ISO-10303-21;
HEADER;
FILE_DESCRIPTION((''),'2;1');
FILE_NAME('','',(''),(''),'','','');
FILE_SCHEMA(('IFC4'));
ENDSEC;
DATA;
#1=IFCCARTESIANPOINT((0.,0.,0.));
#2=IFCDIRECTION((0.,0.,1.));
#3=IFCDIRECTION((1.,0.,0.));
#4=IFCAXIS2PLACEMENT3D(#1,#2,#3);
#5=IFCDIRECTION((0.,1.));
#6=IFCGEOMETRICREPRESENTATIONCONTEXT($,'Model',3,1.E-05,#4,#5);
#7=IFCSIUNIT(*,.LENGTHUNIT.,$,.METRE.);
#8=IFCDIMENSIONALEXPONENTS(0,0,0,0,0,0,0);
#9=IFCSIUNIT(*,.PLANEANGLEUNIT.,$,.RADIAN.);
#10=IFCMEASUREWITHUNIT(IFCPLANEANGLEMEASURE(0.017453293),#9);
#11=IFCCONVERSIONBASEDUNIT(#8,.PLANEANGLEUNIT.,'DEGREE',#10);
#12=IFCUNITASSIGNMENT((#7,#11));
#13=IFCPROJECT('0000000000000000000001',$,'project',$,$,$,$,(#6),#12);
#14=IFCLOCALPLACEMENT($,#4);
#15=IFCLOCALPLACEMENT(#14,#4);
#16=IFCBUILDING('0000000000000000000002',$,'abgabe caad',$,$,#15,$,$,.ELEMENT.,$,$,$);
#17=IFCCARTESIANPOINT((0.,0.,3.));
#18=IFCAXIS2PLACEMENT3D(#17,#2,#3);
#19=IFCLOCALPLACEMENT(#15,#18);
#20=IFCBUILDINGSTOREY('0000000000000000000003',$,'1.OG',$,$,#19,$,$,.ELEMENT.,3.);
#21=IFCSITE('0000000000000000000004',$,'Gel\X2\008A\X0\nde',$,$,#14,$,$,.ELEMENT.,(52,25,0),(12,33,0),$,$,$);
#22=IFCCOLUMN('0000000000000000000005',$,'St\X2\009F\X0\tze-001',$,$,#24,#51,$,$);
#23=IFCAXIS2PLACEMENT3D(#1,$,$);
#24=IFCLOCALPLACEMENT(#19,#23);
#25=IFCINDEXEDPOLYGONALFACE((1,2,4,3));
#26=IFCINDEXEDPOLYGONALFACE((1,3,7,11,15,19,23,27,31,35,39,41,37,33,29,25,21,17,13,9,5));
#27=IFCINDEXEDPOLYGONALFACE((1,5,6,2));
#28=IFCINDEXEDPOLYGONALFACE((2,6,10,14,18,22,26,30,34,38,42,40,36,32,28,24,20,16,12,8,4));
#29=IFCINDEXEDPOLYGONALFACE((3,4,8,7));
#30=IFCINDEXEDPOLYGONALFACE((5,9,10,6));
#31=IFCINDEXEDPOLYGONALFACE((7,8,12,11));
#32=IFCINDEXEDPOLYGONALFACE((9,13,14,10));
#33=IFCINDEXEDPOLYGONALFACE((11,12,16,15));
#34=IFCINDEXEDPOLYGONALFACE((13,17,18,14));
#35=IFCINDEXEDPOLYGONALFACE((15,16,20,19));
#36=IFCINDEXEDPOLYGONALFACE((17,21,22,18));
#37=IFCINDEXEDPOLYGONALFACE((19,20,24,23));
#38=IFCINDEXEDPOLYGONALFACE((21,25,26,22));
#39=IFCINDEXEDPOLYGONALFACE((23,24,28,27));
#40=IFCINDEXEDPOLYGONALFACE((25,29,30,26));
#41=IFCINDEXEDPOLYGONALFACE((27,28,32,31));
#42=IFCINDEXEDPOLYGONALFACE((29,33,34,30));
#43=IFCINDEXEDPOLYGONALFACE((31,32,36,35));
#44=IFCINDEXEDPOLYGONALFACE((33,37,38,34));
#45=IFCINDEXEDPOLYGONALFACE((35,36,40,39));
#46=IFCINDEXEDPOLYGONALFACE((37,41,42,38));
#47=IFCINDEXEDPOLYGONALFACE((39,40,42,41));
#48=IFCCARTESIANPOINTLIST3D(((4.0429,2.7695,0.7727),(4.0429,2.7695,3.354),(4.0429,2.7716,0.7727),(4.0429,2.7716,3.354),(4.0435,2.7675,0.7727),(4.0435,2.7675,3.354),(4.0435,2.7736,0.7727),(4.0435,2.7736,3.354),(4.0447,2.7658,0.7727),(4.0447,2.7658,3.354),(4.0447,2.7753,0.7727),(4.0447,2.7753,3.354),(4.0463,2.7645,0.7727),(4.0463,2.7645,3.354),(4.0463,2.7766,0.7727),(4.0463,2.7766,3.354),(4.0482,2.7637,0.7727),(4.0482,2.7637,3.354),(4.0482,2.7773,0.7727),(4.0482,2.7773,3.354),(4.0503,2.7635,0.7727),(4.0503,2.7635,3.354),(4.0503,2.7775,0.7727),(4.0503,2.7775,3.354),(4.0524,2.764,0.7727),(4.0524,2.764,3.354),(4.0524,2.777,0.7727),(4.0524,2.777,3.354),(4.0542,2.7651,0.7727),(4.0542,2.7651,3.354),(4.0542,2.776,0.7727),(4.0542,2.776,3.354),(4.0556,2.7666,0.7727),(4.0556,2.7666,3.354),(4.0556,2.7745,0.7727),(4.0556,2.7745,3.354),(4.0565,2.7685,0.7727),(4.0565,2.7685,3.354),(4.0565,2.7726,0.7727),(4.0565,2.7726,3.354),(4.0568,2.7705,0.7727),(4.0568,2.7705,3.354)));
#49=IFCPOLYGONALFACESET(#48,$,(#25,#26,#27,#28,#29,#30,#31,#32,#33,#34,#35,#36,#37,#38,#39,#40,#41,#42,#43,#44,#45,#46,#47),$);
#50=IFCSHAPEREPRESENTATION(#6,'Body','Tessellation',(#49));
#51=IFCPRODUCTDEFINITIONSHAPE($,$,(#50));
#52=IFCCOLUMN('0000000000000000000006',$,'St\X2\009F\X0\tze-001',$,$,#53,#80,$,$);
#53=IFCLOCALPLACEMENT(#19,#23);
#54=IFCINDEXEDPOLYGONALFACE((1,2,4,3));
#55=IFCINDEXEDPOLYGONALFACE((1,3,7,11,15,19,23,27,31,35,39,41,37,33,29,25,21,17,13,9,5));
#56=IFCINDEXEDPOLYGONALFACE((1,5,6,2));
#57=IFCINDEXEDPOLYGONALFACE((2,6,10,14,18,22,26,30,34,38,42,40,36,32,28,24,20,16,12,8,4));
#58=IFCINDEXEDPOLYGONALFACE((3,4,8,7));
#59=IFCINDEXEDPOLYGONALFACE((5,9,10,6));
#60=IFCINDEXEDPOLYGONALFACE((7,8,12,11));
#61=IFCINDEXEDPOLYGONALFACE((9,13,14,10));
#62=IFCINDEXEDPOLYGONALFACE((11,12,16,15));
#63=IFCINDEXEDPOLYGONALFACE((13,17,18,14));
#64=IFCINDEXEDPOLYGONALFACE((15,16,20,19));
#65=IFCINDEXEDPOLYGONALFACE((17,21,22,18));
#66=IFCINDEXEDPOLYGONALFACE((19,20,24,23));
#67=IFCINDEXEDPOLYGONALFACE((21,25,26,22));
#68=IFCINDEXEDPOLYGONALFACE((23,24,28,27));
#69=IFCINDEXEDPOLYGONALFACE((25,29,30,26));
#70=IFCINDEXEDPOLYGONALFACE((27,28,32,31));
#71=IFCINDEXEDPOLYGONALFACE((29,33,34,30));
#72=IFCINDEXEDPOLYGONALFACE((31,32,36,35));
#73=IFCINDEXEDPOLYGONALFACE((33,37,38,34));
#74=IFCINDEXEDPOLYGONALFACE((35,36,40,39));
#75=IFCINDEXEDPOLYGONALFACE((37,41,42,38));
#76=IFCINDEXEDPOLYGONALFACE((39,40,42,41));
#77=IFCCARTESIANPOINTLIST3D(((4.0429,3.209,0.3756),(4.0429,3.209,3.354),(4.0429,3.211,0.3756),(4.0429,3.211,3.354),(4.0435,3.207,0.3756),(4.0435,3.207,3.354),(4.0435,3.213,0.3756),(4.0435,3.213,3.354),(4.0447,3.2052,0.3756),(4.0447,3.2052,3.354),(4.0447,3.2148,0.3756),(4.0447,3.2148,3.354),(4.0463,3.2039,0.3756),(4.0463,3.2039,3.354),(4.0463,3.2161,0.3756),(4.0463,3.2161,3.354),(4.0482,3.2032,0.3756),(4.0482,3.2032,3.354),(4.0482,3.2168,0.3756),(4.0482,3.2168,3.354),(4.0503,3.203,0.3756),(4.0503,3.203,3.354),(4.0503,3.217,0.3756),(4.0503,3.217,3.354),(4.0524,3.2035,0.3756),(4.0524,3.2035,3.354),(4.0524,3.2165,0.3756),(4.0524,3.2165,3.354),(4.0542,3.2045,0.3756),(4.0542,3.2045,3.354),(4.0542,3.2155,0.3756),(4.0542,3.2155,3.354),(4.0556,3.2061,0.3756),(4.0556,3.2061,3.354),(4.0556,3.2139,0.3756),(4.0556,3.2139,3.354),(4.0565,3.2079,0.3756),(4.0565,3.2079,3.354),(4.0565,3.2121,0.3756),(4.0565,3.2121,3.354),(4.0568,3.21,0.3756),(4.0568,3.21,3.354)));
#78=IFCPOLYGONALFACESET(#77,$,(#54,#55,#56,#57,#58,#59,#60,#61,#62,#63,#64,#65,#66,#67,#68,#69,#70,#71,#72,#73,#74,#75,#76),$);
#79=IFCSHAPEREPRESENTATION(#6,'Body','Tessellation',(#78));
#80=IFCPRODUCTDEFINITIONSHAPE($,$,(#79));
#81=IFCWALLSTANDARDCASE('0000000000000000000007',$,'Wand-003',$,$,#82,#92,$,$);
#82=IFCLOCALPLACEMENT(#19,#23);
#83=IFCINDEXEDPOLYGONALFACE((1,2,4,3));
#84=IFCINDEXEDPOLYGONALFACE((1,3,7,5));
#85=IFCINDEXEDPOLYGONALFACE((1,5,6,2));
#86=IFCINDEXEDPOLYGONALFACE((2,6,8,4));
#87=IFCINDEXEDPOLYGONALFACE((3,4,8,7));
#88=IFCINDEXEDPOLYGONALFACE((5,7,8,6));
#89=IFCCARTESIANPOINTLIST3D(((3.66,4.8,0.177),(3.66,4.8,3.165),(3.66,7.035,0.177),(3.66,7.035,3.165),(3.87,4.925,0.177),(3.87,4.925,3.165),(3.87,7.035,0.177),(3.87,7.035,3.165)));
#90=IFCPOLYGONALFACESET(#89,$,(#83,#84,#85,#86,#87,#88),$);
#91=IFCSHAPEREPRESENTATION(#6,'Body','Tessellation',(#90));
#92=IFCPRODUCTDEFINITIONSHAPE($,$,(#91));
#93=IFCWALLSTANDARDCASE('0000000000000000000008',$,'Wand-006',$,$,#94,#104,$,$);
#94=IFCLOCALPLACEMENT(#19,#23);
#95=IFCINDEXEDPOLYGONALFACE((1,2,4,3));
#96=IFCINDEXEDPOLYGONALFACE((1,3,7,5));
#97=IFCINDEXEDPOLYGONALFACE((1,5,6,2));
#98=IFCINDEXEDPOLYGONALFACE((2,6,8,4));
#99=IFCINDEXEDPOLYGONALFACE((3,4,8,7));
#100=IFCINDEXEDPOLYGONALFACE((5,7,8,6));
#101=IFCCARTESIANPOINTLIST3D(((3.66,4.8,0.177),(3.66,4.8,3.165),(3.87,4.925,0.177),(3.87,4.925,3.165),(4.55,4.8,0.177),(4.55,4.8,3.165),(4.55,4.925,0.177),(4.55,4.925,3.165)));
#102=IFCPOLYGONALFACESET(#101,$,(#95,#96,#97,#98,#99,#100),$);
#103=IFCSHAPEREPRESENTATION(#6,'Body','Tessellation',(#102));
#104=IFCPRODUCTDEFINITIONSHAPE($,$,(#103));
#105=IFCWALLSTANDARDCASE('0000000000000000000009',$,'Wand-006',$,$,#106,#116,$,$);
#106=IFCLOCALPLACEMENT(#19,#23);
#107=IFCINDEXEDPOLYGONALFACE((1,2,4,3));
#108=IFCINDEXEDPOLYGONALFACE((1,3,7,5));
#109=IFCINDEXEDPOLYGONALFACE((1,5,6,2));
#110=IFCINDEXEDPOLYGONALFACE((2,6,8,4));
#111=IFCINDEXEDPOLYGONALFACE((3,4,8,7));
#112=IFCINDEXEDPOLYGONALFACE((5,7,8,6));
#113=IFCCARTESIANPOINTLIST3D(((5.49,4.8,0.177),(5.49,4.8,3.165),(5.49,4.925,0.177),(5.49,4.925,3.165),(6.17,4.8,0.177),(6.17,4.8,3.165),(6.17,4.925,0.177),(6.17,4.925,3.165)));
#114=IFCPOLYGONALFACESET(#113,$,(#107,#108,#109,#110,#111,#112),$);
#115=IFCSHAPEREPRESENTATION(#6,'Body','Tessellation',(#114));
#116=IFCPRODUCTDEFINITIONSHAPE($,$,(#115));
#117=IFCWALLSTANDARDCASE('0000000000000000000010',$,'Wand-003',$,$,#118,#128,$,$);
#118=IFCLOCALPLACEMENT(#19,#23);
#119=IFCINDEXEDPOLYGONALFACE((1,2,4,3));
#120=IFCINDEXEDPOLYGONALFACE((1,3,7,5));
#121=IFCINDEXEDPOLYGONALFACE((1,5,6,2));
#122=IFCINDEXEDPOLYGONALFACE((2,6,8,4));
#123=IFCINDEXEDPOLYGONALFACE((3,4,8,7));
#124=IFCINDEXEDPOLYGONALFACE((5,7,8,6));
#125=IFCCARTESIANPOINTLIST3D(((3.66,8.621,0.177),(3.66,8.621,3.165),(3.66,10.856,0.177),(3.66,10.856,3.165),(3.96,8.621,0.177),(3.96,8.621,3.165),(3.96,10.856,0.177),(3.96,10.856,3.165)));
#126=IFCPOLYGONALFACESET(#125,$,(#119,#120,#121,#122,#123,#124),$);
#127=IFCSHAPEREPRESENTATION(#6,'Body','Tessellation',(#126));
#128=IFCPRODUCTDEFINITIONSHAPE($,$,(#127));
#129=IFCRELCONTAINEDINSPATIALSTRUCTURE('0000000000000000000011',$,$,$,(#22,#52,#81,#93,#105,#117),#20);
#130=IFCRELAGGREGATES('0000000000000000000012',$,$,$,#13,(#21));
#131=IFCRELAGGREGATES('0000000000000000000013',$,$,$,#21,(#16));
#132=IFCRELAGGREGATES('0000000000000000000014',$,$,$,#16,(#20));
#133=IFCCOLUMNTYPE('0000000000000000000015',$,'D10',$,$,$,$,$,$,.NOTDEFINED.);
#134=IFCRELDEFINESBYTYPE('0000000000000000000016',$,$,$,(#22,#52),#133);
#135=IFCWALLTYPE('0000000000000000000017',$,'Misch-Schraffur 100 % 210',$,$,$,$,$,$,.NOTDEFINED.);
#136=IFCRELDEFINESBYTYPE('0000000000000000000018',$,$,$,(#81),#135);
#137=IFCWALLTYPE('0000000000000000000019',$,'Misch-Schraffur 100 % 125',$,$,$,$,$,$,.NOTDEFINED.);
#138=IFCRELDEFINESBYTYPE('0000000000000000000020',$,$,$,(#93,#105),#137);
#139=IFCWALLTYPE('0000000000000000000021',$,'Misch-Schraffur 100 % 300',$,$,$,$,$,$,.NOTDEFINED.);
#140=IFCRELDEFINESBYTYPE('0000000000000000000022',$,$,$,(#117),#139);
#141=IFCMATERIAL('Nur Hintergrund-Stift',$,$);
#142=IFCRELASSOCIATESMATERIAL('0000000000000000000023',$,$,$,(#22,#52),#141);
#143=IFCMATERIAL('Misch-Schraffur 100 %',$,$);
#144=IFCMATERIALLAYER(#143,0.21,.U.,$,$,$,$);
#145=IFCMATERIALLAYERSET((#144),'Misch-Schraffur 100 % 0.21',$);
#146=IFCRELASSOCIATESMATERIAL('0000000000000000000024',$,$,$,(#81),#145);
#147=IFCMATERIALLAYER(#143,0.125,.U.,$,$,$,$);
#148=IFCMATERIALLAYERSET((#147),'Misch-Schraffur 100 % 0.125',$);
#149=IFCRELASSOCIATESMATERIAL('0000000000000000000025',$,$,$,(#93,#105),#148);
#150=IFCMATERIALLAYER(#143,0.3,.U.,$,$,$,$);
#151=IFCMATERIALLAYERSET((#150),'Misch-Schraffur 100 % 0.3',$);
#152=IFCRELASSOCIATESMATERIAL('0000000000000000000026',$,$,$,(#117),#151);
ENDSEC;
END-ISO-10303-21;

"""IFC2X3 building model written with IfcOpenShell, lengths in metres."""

from ifc_helpers import new_model, entity, si_unit, converted_unit, direction, frame, origin_with_axes, origin_2d_with_axis, place, context, project, spatial, polyline, circle, outline, extrude, material, layer, layer_set, layer_usage, type_object, element, save


model = new_model("IFC2X3")

# Units and contexts
model_context = context("Model", 3, precision=1e-05, world=origin_with_axes(), true_north=direction((0.0, 1.0)))
ifc_project = project(units=[si_unit("LENGTHUNIT", "METRE"), converted_unit("PLANEANGLEUNIT", "DEGREE", entity("IfcPlaneAngleMeasure", 0.017453293), si_unit("PLANEANGLEUNIT", "RADIAN"), dimensions=[0, 0, 0, 0, 0, 0, 0])], contexts=[model_context])

# Site, building, storey
site_placement = place(None, origin_with_axes())
site = spatial("IfcSite", under=ifc_project, at=site_placement, Name="Gel\u008ande", CompositionType="ELEMENT", RefLatitude=(52, 25, 0), RefLongitude=(12, 33, 0))
building_placement = place(site_placement, origin_with_axes())
building = spatial("IfcBuilding", under=site, at=building_placement, Name="abgabe caad", CompositionType="ELEMENT")
storey_placement = place(building_placement, frame((0.0, 0.0, 3.0), z_axis=(0.0, 0.0, 1.0), x_axis=(1.0, 0.0, 0.0)))
storey = spatial("IfcBuildingStorey", under=building, at=storey_placement, Name="1.OG", CompositionType="ELEMENT", Elevation=3.0)

# Columns
ifc_material_1 = material(Name="Nur Hintergrund-Stift")
column_type = type_object("IfcColumnType", Name="D10", PredefinedType="NOTDEFINED")
column_1_placement = place(storey_placement, frame((4.0498, 2.7705, 0.7727), z_axis=(0.0, 0.0, 1.0), x_axis=(1.0, 0.0, 0.0)))
element("IfcColumn", 1, at=column_1_placement, inside=storey, type_object=column_type, material=ifc_material_1, Name="St\u009ftze-001", context=model_context, shape_type="SweptSolid", body=[
    extrude(circle(Radius=0.007, at=origin_2d_with_axis()), origin_with_axes(), (0.0, 0.0, 1.0), 2.5813),
])
column_2_placement = place(storey_placement, frame((4.0498, 3.21, 0.3756), z_axis=(0.0, 0.0, 1.0), x_axis=(1.0, 0.0, 0.0)))
element("IfcColumn", 2, at=column_2_placement, inside=storey, type_object=column_type, material=ifc_material_1, Name="St\u009ftze-001", context=model_context, shape_type="SweptSolid", body=[
    extrude(circle(Radius=0.007, at=origin_2d_with_axis()), origin_with_axes(), (0.0, 0.0, 1.0), 2.9784),
])

# Walls
ifc_material_2 = material(Name="Misch-Schraffur 100 %")
ifc_layer_1 = layer(ifc_material_2, 0.21, ventilated="UNKNOWN")
ifc_layer_set_1 = layer_set([ifc_layer_1], Name="Misch-Schraffur 100 % 0.21")
ifc_layer_usage_1 = layer_usage(ifc_layer_set_1, "AXIS2", "NEGATIVE", 0.0)
wall_type_1 = type_object("IfcWallType", Name="Misch-Schraffur 100 % 210", PredefinedType="NOTDEFINED")
wall_1_placement = place(storey_placement, frame((3.66, 4.8, 0.177), z_axis=(0.0, 0.0, 1.0), x_axis=(0.0, 1.0, 0.0)))
element("IfcWallStandardCase", 3, at=wall_1_placement, inside=storey, type_object=wall_type_1, material=ifc_layer_usage_1, Name="Wand-003", context=model_context, shape_type="SweptSolid", body=[
    extrude(outline(polyline([(0.125, -0.21), (2.235, -0.21), (2.235, 0.0), (0.0, 0.0), (0.125, -0.21)])), origin_with_axes(), (0.0, 0.0, 1.0), 2.988),
])
ifc_layer_2 = layer(ifc_material_2, 0.125, ventilated="UNKNOWN")
ifc_layer_set_2 = layer_set([ifc_layer_2], Name="Misch-Schraffur 100 % 0.125")
ifc_layer_usage_2 = layer_usage(ifc_layer_set_2, "AXIS2", "POSITIVE", 0.0)
wall_type_2 = type_object("IfcWallType", Name="Misch-Schraffur 100 % 125", PredefinedType="NOTDEFINED")
wall_2_placement = place(storey_placement, frame((3.66, 4.8, 0.177), z_axis=(0.0, 0.0, 1.0), x_axis=(1.0, 0.0, 0.0)))
element("IfcWallStandardCase", 4, at=wall_2_placement, inside=storey, type_object=wall_type_2, material=ifc_layer_usage_2, Name="Wand-006", context=model_context, shape_type="SweptSolid", body=[
    extrude(outline(polyline([(0.0, 0.0), (0.89, 0.0), (0.89, 0.125), (0.21, 0.125), (0.0, 0.0)])), origin_with_axes(), (0.0, 0.0, 1.0), 2.988),
])
ifc_layer_usage_3 = layer_usage(ifc_layer_set_2, "AXIS2", "POSITIVE", 0.0)
wall_3_placement = place(storey_placement, frame((5.49, 4.8, 0.177), z_axis=(0.0, 0.0, 1.0), x_axis=(1.0, 0.0, 0.0)))
element("IfcWallStandardCase", 5, at=wall_3_placement, inside=storey, type_object=wall_type_2, material=ifc_layer_usage_3, Name="Wand-006", context=model_context, shape_type="SweptSolid", body=[
    extrude(outline(polyline([(0.0, 0.0), (0.68, 0.0), (0.68, 0.125), (0.0, 0.125), (0.0, 0.0)])), origin_with_axes(), (0.0, 0.0, 1.0), 2.988),
])
ifc_layer_3 = layer(ifc_material_2, 0.3, ventilated="UNKNOWN")
ifc_layer_set_3 = layer_set([ifc_layer_3], Name="Misch-Schraffur 100 % 0.3")
ifc_layer_usage_4 = layer_usage(ifc_layer_set_3, "AXIS2", "NEGATIVE", 0.0)
wall_type_3 = type_object("IfcWallType", Name="Misch-Schraffur 100 % 300", PredefinedType="NOTDEFINED")
wall_4_placement = place(storey_placement, frame((3.66, 8.621, 0.177), z_axis=(0.0, 0.0, 1.0), x_axis=(0.0, 1.0, 0.0)))
element("IfcWallStandardCase", 6, at=wall_4_placement, inside=storey, type_object=wall_type_3, material=ifc_layer_usage_4, Name="Wand-003", context=model_context, shape_type="SweptSolid", body=[
    extrude(outline(polyline([(0.0, -0.3), (2.235, -0.3), (2.235, 0.0), (0.0, 0.0), (0.0, -0.3)])), origin_with_axes(), (0.0, 0.0, 1.0), 2.988),
])

save(model, "model.ifc")
